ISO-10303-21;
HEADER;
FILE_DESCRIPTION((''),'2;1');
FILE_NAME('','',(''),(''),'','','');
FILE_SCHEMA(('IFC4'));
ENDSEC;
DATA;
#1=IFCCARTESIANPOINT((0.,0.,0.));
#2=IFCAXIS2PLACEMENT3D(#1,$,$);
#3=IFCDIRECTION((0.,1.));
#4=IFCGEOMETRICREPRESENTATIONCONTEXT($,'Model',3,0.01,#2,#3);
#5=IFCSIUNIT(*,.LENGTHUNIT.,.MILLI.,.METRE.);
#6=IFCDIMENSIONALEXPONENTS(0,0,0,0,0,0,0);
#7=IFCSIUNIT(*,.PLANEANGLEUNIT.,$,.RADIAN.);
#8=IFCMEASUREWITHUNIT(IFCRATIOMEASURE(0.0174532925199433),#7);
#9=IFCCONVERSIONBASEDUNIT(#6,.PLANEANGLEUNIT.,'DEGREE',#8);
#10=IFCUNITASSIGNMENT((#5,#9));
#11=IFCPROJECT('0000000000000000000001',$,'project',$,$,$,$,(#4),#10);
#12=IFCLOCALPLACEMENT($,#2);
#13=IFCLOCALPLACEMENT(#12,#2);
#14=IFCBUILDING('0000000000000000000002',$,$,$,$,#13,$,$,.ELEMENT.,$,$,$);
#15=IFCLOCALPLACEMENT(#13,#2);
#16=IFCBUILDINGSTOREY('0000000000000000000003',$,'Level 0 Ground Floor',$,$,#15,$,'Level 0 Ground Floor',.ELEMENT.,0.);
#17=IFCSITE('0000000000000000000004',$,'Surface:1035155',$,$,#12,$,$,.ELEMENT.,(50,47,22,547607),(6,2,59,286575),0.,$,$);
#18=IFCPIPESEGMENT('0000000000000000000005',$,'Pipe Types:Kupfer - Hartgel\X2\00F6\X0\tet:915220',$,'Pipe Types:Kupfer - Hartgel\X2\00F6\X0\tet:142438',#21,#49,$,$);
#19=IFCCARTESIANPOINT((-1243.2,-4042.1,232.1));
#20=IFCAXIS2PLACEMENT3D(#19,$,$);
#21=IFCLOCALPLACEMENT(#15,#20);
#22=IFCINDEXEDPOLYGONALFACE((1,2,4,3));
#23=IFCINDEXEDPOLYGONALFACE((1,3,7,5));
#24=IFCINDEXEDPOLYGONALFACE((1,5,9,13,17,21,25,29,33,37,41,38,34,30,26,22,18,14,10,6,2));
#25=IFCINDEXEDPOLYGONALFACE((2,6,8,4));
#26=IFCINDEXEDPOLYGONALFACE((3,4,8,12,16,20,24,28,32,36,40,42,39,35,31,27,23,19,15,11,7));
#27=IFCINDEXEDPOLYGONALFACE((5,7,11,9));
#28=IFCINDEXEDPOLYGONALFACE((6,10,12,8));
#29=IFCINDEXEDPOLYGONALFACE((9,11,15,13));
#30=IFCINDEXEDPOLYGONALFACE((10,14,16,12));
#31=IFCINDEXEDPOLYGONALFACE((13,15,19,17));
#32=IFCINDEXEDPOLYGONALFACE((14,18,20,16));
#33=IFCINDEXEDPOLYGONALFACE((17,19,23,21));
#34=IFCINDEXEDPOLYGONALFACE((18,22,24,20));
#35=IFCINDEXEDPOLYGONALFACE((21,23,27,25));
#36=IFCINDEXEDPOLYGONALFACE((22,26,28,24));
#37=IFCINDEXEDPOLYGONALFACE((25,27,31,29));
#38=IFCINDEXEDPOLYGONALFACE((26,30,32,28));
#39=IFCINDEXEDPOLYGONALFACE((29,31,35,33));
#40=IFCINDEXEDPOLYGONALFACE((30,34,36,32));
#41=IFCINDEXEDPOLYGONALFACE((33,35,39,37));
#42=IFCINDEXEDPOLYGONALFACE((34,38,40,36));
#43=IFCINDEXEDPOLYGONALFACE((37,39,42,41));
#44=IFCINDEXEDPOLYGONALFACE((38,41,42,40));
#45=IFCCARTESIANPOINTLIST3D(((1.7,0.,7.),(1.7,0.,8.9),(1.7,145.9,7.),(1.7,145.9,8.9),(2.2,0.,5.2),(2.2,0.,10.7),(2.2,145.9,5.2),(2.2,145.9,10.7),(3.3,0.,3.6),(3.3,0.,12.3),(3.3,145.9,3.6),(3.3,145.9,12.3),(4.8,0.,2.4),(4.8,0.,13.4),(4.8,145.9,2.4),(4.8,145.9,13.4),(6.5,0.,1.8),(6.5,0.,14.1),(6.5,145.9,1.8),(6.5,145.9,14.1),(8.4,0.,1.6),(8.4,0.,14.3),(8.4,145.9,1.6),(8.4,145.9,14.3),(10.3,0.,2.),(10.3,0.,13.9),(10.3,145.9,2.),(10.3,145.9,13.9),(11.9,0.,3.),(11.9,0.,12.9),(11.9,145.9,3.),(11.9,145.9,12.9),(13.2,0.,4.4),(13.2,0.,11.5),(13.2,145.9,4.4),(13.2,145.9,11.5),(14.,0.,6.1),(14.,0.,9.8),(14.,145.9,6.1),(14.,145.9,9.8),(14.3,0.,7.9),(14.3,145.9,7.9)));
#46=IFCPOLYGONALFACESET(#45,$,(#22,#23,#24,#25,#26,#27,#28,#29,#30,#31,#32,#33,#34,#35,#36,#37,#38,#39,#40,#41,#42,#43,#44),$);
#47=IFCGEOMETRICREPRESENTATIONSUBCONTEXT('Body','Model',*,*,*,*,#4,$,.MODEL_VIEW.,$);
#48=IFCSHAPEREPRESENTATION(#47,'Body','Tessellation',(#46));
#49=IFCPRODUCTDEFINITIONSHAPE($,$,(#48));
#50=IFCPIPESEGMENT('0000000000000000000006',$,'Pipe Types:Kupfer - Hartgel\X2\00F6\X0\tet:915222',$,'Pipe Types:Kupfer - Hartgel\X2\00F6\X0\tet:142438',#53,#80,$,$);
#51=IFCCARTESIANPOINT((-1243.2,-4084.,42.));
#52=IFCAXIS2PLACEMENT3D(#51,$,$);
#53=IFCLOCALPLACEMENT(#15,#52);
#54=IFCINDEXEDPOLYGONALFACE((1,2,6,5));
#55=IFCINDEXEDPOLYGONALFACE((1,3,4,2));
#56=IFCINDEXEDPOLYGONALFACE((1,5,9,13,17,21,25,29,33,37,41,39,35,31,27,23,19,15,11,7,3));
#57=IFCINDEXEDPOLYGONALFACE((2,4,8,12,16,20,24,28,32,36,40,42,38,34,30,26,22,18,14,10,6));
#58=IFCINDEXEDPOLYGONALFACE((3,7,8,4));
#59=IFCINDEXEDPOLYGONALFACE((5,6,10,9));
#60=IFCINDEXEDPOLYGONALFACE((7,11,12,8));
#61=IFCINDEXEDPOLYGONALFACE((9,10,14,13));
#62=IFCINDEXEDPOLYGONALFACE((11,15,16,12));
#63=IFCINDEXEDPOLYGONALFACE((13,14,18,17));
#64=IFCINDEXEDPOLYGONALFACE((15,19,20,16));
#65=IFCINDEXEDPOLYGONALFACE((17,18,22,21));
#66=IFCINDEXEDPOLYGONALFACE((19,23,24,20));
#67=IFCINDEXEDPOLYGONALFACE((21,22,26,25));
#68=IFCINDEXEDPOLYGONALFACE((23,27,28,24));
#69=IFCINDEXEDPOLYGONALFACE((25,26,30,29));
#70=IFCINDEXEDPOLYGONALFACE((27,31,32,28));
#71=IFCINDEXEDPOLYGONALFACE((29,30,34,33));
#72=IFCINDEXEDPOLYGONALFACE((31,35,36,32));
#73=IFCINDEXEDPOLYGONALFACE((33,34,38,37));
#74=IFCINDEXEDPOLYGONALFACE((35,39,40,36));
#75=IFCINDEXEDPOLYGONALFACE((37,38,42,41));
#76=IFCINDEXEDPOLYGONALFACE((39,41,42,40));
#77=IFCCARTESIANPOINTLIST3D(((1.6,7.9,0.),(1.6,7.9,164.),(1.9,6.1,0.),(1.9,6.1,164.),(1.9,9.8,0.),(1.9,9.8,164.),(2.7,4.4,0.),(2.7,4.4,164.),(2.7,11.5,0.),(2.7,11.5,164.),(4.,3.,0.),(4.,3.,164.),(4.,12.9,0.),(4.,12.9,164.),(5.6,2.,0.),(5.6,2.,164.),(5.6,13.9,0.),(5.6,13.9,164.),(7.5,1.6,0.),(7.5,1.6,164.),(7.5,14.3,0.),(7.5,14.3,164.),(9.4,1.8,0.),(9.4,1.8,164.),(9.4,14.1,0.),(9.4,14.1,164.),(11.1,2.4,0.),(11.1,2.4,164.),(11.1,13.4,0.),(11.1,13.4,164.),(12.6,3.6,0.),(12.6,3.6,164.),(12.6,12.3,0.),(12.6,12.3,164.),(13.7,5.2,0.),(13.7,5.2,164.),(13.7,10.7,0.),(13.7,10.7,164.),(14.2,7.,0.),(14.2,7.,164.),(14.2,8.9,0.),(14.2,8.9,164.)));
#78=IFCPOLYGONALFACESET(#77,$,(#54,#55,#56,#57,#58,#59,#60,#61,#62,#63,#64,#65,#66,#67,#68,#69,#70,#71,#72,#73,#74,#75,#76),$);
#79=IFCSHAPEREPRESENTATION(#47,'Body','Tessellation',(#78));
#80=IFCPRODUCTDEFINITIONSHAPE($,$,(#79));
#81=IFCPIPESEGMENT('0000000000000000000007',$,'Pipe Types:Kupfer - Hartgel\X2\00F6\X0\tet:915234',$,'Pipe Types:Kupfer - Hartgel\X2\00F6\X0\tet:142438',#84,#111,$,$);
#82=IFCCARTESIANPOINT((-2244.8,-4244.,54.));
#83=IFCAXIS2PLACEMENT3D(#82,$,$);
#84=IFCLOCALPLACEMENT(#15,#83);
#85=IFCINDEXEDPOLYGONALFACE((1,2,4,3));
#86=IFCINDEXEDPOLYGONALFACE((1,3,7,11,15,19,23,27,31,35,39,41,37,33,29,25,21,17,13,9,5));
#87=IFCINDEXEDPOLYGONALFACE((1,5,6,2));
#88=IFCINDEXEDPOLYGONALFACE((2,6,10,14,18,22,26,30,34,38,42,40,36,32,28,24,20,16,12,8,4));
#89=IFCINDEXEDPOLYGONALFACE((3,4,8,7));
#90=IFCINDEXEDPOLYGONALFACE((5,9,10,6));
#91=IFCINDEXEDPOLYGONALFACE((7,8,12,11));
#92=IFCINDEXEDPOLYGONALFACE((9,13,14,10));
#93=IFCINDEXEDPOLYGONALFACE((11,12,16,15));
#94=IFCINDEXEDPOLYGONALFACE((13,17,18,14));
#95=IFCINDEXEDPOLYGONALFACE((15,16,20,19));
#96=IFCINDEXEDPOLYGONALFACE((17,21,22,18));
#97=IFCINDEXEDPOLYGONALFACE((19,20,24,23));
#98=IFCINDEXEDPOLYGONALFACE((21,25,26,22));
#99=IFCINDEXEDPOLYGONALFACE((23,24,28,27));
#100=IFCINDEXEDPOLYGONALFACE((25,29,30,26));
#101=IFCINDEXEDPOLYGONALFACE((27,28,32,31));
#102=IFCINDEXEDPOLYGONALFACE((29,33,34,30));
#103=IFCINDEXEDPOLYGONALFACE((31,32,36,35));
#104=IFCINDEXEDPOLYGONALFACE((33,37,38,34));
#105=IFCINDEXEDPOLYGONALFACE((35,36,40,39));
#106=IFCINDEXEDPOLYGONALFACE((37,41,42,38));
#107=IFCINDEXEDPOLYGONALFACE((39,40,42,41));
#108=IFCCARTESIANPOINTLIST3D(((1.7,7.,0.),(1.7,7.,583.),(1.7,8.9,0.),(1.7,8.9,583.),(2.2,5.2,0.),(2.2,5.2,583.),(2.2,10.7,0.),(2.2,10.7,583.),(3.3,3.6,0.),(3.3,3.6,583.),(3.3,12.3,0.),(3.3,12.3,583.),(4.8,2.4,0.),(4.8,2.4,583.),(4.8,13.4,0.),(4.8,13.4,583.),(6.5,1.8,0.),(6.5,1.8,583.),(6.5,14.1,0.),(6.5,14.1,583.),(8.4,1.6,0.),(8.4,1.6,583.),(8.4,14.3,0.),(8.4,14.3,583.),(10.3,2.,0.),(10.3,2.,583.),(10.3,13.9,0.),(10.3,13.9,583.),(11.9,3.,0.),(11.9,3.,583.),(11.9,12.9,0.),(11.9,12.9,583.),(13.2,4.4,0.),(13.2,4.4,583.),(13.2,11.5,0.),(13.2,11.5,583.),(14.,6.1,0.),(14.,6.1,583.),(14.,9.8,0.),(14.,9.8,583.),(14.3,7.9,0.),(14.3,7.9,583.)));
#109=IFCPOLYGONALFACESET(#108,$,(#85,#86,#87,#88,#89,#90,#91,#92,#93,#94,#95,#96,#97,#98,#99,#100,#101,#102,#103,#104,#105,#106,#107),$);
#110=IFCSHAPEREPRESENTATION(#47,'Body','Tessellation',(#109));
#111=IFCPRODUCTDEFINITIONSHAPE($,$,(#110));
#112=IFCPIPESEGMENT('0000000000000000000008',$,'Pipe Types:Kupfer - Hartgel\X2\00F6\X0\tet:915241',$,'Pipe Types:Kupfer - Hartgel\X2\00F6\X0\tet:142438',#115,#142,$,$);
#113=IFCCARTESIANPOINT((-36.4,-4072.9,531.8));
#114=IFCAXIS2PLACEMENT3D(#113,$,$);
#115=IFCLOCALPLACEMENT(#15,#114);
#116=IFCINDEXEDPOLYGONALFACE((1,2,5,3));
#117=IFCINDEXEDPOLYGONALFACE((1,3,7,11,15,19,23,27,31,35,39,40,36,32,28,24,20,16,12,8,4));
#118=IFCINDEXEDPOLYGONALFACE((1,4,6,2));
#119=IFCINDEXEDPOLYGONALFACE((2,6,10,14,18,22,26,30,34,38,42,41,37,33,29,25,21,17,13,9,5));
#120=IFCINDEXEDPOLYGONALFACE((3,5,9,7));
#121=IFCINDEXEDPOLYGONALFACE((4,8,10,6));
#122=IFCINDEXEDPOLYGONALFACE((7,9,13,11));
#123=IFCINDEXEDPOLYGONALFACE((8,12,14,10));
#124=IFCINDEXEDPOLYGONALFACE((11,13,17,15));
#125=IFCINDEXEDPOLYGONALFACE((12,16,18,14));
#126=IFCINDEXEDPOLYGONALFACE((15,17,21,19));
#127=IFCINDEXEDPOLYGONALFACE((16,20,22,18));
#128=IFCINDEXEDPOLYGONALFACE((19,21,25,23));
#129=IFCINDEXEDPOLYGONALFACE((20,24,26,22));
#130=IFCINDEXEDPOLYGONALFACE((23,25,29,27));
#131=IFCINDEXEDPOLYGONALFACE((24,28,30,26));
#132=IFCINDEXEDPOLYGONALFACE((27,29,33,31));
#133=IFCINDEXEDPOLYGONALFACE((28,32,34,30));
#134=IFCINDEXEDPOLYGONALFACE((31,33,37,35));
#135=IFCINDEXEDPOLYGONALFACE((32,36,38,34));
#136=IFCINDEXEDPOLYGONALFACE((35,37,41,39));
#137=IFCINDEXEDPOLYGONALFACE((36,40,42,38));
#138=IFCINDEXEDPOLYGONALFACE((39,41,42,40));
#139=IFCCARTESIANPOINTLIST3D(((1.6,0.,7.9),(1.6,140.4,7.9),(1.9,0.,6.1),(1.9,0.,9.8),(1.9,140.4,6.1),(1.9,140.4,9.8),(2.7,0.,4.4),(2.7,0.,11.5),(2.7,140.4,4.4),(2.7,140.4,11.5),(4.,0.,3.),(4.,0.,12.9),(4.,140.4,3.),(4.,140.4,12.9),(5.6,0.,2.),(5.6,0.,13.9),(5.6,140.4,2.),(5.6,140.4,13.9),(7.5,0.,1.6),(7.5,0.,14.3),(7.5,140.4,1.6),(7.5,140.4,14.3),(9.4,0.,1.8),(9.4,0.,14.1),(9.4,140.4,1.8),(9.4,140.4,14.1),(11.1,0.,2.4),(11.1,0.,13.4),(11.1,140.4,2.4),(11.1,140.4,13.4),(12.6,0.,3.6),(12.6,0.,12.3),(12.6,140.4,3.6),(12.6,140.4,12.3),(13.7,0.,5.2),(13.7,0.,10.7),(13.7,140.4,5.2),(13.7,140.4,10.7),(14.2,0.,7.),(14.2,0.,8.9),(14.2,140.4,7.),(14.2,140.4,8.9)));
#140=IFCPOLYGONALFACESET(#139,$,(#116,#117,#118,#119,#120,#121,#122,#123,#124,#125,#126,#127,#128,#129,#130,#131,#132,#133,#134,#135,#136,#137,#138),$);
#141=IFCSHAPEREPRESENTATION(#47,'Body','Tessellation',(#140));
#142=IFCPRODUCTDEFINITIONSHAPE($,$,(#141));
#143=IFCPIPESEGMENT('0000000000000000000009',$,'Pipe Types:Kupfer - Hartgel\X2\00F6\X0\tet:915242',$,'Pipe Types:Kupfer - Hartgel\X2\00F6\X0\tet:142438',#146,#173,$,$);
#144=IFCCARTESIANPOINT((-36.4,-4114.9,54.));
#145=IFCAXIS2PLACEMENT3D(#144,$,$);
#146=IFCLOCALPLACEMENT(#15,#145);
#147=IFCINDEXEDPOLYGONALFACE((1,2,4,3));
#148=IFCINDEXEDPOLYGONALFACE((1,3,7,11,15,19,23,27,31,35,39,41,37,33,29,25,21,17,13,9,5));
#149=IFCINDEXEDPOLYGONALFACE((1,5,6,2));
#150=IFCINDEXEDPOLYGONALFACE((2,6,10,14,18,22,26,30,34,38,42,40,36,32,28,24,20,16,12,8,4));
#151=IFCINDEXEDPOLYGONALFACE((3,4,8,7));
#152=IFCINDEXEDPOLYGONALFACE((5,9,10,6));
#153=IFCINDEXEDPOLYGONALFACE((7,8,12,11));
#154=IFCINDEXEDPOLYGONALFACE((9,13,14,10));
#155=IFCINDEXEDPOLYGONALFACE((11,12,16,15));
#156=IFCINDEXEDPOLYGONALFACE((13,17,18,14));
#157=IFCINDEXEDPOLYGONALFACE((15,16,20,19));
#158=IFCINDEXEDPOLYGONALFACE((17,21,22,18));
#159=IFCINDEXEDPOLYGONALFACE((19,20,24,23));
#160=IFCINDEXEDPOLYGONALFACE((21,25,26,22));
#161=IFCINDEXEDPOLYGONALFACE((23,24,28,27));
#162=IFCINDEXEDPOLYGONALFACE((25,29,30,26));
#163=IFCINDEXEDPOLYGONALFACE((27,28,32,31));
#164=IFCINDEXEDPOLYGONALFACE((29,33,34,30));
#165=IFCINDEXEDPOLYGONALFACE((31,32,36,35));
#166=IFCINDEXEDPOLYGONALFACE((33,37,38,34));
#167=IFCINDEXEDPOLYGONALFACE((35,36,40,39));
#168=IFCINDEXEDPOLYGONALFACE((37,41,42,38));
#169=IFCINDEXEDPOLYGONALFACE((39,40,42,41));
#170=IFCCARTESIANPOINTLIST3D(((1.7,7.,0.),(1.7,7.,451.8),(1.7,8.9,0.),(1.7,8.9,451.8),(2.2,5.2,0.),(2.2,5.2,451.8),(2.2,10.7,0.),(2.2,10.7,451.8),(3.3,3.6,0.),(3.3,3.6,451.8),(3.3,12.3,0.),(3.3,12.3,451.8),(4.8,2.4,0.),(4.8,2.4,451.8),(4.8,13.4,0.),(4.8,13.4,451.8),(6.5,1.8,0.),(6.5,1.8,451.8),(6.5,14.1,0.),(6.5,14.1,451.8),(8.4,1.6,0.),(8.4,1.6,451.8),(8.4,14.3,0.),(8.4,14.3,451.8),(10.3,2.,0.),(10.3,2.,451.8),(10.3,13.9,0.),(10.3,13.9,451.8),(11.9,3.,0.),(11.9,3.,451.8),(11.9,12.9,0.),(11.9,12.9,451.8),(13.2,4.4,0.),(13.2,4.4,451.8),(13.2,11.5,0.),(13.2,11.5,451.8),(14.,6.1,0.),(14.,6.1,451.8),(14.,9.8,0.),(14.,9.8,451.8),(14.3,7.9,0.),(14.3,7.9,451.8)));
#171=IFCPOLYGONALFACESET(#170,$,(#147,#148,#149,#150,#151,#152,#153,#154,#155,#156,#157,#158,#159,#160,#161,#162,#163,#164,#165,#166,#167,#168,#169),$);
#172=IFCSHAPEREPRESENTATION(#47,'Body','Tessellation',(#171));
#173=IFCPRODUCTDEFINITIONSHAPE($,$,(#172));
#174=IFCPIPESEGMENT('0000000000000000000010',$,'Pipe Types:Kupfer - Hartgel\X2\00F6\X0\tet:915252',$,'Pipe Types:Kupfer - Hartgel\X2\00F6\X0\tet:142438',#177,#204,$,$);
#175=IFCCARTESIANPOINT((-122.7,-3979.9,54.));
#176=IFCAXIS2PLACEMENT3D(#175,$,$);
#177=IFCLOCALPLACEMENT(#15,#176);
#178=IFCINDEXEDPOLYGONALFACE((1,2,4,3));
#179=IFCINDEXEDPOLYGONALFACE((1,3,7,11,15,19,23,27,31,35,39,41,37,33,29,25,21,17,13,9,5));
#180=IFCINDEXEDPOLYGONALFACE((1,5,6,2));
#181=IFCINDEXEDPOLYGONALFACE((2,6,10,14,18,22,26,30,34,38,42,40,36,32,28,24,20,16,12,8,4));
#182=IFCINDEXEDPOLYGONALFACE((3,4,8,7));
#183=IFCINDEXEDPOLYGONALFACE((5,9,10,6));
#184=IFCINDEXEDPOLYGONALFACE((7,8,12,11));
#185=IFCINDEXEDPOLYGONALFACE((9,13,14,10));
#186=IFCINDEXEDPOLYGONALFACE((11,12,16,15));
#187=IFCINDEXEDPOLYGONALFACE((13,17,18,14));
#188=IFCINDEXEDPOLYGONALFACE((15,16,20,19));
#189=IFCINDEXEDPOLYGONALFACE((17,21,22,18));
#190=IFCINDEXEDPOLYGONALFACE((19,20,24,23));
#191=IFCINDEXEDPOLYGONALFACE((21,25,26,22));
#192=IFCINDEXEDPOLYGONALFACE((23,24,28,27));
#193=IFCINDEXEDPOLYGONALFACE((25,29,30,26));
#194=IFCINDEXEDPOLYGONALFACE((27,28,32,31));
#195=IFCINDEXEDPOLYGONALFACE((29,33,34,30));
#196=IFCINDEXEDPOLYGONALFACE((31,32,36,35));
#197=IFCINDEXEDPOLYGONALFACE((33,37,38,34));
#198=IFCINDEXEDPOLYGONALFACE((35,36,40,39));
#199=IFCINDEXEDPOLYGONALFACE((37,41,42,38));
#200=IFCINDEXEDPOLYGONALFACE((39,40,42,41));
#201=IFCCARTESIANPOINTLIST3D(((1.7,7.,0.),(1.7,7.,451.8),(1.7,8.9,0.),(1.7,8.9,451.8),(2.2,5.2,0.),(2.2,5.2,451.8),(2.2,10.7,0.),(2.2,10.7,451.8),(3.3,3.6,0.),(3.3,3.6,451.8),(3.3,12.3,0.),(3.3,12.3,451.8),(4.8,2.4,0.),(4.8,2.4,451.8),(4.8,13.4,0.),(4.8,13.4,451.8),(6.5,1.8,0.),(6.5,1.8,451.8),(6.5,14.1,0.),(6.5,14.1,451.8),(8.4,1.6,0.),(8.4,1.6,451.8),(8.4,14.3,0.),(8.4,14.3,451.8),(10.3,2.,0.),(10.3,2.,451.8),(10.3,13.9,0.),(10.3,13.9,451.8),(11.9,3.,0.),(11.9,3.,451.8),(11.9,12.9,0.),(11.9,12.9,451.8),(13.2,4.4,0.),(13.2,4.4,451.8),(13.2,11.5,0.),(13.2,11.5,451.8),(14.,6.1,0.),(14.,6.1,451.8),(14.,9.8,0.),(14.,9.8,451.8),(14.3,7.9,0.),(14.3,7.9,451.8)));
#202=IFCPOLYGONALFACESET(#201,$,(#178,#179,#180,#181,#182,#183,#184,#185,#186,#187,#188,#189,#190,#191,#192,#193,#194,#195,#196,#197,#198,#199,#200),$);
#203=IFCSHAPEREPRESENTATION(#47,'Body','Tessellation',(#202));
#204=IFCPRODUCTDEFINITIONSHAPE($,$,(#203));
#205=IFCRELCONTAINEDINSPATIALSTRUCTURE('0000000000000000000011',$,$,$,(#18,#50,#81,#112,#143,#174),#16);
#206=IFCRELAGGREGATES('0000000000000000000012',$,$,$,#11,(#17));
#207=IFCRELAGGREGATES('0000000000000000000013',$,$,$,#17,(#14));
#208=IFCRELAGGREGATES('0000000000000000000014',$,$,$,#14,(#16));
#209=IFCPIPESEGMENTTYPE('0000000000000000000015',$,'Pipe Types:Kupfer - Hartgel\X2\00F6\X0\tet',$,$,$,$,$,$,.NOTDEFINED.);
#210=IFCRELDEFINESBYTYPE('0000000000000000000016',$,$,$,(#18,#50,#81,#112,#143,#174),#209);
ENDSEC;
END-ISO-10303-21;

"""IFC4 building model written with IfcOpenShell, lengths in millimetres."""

from ifc_helpers import new_model, entity, si_unit, converted_unit, direction, frame, frame_2d, origin, origin_2d_with_axis, place, context, subcontext, project, spatial, circle, extrude, type_object, element, save


model = new_model("IFC4")

# Units and contexts
model_context = context("Model", 3, precision=0.01, world=origin(), true_north=direction((0.0, 1.0)))
body_context = subcontext(model_context, "Body", "Model", "MODEL_VIEW")
ifc_project = project(units=[si_unit("LENGTHUNIT", "METRE", prefix="MILLI"), converted_unit("PLANEANGLEUNIT", "DEGREE", entity("IfcRatioMeasure", 0.0174532925199433), si_unit("PLANEANGLEUNIT", "RADIAN"), dimensions=[0, 0, 0, 0, 0, 0, 0])], contexts=[model_context])

# Site, building, storey
site_placement = place(None, origin())
site = spatial("IfcSite", under=ifc_project, at=site_placement, Name="Surface:1035155", CompositionType="ELEMENT", RefLatitude=(50, 47, 22, 547607), RefLongitude=(6, 2, 59, 286575), RefElevation=0.0)
building_placement = place(site_placement, origin())
building = spatial("IfcBuilding", under=site, at=building_placement, CompositionType="ELEMENT")
storey_placement = place(building_placement, origin())
storey = spatial("IfcBuildingStorey", under=building, at=storey_placement, Name="Level 0 Ground Floor", LongName="Level 0 Ground Floor", CompositionType="ELEMENT", Elevation=0.0)

# Pipe segments
pipe_segment_type = type_object("IfcPipeSegmentType", Name="Pipe Types:Kupfer - Hartgelötet", PredefinedType="NOTDEFINED")
pipe_segment_1_placement = place(storey_placement, frame((-1243.2, -4042.1, 232.1)))
element("IfcPipeSegment", 1, at=pipe_segment_1_placement, inside=storey, type_object=pipe_segment_type, Name="Pipe Types:Kupfer - Hartgelötet:915220", ObjectType="Pipe Types:Kupfer - Hartgelötet:142438", context=body_context, shape_type="SweptSolid", body=[
    extrude(circle(Radius=6.3, at=frame_2d((0.0, 0.0), x_axis=(1.0, 0.0))), frame((7.9, 0.0, 7.9), z_axis=(0.0, 1.0, 0.0), x_axis=(1.0, 0.0, 0.0)), (0.0, 0.0, 1.0), 145.9),
])
pipe_segment_2_placement = place(storey_placement, frame((-1243.2, -4084.0, 42.0)))
element("IfcPipeSegment", 2, at=pipe_segment_2_placement, inside=storey, type_object=pipe_segment_type, Name="Pipe Types:Kupfer - Hartgelötet:915222", ObjectType="Pipe Types:Kupfer - Hartgelötet:142438", context=body_context, shape_type="SweptSolid", body=[
    extrude(circle(Radius=6.3, at=frame_2d((0.0, 0.0), x_axis=(1.0, 0.0))), frame((7.9, 7.9, 0.0), z_axis=(0.0, 0.0, 1.0), x_axis=(-1.0, 0.0, 0.0)), (0.0, 0.0, 1.0), 164.0),
])
pipe_segment_3_placement = place(storey_placement, frame((-2244.8, -4244.0, 54.0)))
element("IfcPipeSegment", 3, at=pipe_segment_3_placement, inside=storey, type_object=pipe_segment_type, Name="Pipe Types:Kupfer - Hartgelötet:915234", ObjectType="Pipe Types:Kupfer - Hartgelötet:142438", context=body_context, shape_type="SweptSolid", body=[
    extrude(circle(Radius=6.3, at=frame_2d((0.0, 0.0), x_axis=(1.0, 0.0))), frame((7.9, 7.9, 0.0)), (0.0, 0.0, 1.0), 583.0),
])
pipe_segment_4_placement = place(storey_placement, frame((-36.4, -4072.9, 531.8)))
element("IfcPipeSegment", 4, at=pipe_segment_4_placement, inside=storey, type_object=pipe_segment_type, Name="Pipe Types:Kupfer - Hartgelötet:915241", ObjectType="Pipe Types:Kupfer - Hartgelötet:142438", context=body_context, shape_type="SweptSolid", body=[
    extrude(circle(Radius=6.3, at=frame_2d((0.0, 0.0), x_axis=(1.0, 0.0))), frame((7.9, 0.0, 7.9), z_axis=(0.0, 1.0, 0.0), x_axis=(-1.0, 0.0, 0.0)), (0.0, 0.0, 1.0), 140.4),
])
pipe_segment_5_placement = place(storey_placement, frame((-36.4, -4114.9, 54.0)))
element("IfcPipeSegment", 5, at=pipe_segment_5_placement, inside=storey, type_object=pipe_segment_type, Name="Pipe Types:Kupfer - Hartgelötet:915242", ObjectType="Pipe Types:Kupfer - Hartgelötet:142438", context=body_context, shape_type="SweptSolid", body=[
    extrude(circle(Radius=6.3, at=frame_2d((0.0, 0.0), x_axis=(1.0, 0.0))), frame((7.9, 7.9, 0.0)), (0.0, 0.0, 1.0), 451.8),
])
pipe_segment_6_placement = place(storey_placement, frame((-122.7, -3979.9, 54.0)))
element("IfcPipeSegment", 6, at=pipe_segment_6_placement, inside=storey, type_object=pipe_segment_type, Name="Pipe Types:Kupfer - Hartgelötet:915252", ObjectType="Pipe Types:Kupfer - Hartgelötet:142438", context=body_context, shape_type="SweptSolid", body=[
    extrude(circle(Radius=6.3, at=origin_2d_with_axis()), frame((7.9, 7.9, 0.0)), (0.0, 0.0, 1.0), 451.8),
])

save(model, "model.ifc")
